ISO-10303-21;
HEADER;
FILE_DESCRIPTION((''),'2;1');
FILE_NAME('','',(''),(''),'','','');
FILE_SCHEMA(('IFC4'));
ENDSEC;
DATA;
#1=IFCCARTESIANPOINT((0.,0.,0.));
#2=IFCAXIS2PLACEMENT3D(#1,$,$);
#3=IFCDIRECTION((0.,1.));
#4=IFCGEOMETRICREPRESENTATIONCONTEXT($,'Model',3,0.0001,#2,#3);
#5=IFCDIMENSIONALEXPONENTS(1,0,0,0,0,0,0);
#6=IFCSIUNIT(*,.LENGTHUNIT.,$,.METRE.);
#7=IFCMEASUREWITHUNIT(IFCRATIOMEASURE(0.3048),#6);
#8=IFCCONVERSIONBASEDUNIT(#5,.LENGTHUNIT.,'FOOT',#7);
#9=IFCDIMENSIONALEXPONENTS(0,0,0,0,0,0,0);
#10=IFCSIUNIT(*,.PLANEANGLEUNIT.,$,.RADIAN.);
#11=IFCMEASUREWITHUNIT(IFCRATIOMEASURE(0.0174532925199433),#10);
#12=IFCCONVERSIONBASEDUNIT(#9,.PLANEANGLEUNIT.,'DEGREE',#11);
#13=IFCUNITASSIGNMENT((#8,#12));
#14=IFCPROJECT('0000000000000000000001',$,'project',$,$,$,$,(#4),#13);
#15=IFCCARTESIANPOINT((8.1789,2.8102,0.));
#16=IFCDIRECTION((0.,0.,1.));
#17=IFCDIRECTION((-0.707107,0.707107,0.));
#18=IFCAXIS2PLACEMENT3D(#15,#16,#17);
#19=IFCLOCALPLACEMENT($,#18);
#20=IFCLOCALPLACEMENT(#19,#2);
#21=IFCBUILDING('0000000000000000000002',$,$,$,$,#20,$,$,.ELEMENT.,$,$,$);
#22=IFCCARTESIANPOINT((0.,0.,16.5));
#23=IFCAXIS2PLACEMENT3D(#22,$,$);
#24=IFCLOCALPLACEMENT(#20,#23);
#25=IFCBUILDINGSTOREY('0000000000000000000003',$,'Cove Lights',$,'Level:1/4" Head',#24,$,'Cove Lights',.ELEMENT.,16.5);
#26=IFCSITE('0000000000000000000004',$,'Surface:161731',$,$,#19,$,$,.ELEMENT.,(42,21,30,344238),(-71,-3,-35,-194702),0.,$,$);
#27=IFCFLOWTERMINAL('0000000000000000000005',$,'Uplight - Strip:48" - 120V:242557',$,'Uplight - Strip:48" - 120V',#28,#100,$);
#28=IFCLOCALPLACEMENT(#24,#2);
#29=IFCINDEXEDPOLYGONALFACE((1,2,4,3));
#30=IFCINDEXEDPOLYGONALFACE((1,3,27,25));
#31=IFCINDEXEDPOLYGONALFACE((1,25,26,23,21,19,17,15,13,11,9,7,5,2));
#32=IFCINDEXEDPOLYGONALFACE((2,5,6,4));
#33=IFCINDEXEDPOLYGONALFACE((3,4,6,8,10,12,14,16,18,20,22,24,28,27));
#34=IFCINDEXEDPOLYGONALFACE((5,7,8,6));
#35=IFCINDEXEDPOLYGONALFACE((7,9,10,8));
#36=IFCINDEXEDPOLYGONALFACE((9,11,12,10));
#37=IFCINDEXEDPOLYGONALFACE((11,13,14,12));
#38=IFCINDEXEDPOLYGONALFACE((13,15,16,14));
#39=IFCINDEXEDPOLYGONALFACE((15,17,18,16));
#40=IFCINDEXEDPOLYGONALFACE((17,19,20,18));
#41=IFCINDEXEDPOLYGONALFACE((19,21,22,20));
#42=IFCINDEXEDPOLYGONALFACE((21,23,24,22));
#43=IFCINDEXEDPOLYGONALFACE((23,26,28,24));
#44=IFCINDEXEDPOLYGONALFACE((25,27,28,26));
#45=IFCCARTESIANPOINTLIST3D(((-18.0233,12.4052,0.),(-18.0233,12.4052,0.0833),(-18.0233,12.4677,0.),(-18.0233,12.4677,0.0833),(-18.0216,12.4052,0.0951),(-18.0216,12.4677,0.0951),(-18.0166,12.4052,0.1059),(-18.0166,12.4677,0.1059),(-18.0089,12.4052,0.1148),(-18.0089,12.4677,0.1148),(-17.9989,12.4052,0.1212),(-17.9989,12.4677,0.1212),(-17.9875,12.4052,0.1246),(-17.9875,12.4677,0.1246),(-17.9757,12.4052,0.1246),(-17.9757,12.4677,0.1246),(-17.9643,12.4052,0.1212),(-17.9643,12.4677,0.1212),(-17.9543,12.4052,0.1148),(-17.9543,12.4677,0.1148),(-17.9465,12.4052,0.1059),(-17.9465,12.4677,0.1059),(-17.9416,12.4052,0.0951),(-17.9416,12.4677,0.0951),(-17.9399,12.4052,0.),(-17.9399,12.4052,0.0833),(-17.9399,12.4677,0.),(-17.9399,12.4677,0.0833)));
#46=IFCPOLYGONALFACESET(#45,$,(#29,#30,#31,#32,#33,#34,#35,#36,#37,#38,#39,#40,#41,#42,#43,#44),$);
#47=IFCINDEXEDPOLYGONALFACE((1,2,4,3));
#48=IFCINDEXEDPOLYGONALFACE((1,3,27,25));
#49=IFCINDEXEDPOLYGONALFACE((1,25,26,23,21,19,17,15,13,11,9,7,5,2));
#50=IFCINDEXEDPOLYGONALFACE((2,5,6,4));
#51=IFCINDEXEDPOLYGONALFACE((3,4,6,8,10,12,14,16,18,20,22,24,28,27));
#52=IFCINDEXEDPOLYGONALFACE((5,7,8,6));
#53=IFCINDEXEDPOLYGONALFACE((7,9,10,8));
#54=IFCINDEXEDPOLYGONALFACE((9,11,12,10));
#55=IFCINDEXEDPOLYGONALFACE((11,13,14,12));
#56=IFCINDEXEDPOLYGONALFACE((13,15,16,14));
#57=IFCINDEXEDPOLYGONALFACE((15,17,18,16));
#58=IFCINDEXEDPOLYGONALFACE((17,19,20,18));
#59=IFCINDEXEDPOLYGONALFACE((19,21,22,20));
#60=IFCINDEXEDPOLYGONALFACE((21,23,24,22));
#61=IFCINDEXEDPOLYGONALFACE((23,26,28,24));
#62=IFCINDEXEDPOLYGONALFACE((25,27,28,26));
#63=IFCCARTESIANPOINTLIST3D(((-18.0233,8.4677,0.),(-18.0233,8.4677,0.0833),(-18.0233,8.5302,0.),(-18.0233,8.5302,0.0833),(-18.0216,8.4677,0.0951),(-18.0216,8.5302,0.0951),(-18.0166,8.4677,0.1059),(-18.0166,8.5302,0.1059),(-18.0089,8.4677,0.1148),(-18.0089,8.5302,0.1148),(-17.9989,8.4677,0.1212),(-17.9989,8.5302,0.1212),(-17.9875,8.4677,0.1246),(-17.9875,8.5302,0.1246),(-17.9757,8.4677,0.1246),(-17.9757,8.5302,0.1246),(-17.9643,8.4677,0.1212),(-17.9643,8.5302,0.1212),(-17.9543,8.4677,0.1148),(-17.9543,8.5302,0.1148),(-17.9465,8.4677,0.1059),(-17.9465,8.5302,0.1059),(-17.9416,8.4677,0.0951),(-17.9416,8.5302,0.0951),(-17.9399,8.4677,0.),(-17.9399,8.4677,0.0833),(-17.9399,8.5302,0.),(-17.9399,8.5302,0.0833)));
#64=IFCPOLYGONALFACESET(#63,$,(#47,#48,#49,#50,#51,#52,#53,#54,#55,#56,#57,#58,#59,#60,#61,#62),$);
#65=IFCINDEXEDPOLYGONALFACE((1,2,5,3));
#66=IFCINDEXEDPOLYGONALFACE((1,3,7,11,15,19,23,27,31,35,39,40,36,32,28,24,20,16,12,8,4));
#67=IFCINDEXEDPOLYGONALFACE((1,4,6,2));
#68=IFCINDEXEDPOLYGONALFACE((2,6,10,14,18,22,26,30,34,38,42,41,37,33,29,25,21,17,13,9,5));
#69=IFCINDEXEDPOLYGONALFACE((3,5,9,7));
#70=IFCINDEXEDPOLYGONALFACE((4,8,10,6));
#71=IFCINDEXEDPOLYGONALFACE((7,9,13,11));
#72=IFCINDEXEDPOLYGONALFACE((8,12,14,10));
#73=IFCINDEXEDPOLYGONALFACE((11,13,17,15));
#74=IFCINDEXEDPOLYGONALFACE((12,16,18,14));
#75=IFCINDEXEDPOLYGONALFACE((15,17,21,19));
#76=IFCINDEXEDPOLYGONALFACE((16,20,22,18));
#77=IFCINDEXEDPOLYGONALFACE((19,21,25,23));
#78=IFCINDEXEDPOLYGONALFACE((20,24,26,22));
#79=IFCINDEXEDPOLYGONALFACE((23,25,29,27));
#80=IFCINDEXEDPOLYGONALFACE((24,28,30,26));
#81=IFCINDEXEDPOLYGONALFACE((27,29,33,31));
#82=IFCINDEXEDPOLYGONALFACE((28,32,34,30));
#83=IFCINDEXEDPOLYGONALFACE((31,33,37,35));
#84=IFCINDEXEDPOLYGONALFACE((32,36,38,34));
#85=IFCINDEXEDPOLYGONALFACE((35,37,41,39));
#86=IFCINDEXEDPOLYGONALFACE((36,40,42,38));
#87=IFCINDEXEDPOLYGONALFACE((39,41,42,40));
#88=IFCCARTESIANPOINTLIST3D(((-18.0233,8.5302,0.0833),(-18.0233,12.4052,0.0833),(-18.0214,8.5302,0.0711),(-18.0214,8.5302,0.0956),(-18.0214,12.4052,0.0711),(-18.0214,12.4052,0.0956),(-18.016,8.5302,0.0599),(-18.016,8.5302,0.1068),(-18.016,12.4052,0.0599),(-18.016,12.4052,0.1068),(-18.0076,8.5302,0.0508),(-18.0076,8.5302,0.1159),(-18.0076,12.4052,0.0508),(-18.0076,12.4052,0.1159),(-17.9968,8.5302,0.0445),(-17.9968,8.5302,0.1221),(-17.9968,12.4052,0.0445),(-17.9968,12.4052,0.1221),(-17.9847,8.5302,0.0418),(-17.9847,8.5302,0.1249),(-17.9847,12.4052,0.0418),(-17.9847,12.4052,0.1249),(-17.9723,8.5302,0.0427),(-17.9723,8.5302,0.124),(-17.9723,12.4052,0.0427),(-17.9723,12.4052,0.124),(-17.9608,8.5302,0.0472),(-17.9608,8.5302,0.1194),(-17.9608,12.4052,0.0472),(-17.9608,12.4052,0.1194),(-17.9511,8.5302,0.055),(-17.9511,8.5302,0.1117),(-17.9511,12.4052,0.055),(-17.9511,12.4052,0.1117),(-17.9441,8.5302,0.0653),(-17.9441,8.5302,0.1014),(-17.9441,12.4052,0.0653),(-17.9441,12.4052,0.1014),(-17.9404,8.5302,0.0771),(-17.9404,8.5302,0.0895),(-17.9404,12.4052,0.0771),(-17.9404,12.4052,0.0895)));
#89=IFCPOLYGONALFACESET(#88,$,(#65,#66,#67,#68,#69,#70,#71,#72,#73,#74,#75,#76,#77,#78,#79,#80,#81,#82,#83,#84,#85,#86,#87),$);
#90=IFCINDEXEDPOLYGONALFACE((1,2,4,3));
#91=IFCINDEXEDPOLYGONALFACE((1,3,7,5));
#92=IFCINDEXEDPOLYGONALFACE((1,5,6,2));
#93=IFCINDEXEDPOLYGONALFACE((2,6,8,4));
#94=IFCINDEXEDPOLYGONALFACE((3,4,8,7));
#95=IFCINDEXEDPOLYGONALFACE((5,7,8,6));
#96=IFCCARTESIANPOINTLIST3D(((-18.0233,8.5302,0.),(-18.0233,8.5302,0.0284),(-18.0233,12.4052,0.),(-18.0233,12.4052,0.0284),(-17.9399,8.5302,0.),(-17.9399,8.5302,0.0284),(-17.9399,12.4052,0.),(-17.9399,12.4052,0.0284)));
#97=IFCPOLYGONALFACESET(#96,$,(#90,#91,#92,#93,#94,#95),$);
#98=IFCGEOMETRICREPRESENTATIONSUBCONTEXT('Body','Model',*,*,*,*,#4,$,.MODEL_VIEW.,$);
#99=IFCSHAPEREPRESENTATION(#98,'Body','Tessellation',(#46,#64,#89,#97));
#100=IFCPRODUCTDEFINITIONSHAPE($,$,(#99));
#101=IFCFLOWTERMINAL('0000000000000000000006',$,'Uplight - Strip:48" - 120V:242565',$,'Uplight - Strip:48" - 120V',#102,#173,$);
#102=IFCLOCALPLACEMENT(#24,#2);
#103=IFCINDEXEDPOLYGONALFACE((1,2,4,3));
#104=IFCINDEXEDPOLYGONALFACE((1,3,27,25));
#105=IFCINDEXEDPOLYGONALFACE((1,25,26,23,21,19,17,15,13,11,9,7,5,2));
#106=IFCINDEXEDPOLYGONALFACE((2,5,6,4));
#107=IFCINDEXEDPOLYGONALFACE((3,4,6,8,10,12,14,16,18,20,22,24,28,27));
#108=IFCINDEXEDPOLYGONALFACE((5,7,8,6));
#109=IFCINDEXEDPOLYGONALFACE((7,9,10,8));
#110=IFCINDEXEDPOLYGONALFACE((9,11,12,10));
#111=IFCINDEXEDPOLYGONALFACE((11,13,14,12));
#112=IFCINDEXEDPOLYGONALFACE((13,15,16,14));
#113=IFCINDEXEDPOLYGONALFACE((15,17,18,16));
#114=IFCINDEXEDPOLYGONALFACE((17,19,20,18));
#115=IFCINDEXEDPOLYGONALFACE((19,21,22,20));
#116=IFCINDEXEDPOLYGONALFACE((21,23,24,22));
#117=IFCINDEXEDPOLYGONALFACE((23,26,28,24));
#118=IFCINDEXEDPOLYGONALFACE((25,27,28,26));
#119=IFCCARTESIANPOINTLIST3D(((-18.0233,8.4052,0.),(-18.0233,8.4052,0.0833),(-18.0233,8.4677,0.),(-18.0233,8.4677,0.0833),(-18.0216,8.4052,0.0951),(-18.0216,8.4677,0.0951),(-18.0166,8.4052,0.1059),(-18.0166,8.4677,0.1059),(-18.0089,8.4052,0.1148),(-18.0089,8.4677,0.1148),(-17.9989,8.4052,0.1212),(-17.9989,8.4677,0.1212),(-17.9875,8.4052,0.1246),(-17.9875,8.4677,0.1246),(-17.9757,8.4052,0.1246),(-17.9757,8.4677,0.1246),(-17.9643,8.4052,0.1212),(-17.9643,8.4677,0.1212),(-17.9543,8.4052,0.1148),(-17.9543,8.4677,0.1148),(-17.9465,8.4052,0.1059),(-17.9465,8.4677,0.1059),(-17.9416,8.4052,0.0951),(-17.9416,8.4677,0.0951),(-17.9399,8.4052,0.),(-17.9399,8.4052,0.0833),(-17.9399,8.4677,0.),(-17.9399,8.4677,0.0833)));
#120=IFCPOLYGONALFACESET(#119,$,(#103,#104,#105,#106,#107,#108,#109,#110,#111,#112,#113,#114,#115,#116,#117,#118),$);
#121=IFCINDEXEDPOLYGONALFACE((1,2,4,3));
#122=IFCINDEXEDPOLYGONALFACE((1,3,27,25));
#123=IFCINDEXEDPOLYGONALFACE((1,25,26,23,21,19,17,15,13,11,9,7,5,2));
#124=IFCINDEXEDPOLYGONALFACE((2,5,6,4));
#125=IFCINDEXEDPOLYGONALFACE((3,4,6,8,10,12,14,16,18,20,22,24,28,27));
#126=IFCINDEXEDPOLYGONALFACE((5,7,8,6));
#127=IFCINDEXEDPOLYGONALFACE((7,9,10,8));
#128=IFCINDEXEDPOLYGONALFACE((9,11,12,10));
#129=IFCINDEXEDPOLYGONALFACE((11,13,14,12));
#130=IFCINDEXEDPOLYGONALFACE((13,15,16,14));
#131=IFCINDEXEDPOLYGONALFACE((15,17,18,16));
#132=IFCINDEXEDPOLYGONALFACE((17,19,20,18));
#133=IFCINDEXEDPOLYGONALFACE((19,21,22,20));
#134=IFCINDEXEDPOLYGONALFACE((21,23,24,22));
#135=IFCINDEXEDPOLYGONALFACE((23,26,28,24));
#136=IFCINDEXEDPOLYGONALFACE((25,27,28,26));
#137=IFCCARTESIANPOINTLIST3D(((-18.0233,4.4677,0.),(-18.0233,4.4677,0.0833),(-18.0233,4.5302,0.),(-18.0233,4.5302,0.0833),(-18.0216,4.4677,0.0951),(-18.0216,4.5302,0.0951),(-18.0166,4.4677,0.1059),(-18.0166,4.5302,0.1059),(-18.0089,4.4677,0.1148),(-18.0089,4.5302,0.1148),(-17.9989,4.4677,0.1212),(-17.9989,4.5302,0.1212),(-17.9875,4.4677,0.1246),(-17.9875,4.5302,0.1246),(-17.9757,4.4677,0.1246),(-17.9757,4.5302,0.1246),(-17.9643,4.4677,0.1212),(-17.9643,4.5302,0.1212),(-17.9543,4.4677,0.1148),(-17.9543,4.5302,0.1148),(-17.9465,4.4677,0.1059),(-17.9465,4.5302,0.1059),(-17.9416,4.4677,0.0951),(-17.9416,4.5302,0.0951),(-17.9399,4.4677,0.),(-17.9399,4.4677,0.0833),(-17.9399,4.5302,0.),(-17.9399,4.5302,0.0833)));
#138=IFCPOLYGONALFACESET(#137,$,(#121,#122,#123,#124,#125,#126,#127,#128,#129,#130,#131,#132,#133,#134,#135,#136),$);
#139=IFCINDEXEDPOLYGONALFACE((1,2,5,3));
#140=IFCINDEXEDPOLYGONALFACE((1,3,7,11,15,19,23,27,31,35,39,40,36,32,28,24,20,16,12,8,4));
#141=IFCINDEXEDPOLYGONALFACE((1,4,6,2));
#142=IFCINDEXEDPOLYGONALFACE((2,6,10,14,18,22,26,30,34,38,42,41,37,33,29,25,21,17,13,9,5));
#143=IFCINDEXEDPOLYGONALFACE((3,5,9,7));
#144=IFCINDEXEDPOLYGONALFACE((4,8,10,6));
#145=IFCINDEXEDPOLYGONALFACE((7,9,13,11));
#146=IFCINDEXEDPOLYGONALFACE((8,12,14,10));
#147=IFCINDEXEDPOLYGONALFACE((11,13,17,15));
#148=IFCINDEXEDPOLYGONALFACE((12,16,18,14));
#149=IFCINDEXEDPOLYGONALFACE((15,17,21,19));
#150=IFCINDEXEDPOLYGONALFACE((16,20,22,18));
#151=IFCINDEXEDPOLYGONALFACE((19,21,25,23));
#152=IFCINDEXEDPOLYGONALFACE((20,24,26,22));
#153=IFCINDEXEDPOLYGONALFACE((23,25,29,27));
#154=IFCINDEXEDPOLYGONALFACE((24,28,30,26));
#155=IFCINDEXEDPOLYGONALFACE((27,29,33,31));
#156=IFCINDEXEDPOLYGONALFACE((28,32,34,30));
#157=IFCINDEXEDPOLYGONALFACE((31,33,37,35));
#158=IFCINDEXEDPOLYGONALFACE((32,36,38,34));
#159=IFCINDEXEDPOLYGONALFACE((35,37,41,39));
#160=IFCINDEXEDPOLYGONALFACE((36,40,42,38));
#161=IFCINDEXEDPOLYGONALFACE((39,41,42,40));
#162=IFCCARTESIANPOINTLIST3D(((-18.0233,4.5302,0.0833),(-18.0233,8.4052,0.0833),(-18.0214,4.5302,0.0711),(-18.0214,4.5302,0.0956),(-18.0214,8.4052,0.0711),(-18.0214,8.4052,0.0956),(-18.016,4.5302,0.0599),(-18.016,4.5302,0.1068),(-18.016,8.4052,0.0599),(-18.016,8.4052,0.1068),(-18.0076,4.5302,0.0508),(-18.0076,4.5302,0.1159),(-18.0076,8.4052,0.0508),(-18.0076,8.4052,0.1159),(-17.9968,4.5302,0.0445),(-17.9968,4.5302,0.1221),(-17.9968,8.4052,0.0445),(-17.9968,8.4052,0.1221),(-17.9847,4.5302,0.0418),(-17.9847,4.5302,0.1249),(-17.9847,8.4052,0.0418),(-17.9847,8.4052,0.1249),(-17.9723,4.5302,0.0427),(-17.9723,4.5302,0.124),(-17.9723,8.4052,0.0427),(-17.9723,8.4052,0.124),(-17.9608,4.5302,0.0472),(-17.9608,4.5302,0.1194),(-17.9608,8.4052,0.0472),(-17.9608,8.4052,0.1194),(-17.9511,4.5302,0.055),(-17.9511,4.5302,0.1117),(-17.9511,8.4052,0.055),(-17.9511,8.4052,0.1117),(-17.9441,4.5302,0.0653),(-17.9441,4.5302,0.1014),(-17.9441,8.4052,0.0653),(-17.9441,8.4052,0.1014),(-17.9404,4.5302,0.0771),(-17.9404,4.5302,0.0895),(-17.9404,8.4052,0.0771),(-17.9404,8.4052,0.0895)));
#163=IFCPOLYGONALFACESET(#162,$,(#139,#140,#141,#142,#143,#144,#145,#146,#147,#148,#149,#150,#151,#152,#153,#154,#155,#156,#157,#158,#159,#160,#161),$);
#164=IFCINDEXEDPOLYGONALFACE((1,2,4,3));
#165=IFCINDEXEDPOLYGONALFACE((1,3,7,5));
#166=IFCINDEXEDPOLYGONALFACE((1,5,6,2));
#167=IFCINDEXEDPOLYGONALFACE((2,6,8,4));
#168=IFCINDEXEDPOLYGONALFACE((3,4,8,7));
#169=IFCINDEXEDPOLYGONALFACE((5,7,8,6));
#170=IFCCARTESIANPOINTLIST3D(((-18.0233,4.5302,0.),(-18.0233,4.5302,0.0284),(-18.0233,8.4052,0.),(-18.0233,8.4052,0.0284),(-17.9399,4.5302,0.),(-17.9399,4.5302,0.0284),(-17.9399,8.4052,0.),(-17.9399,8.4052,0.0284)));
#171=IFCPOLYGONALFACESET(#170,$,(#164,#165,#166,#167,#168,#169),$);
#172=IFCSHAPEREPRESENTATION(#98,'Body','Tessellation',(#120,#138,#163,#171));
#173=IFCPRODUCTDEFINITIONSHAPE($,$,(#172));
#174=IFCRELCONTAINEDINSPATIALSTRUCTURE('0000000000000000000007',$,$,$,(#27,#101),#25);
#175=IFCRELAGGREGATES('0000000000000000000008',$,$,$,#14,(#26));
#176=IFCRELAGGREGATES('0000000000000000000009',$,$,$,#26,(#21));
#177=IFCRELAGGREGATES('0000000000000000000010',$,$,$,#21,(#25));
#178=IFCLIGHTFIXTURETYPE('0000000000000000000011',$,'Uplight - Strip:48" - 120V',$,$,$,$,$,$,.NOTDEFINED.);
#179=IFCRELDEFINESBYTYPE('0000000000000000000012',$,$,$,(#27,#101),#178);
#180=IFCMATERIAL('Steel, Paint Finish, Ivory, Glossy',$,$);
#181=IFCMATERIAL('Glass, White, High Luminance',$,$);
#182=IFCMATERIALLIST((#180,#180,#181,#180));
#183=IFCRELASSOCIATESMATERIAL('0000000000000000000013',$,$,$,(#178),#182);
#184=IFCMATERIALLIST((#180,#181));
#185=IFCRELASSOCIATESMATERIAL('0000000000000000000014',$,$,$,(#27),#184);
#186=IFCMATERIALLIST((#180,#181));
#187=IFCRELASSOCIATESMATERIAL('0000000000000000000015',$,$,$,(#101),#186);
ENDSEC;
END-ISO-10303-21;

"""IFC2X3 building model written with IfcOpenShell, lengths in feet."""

from ifc_helpers import new_model, entity, si_unit, converted_unit, direction, frame, frame_2d, origin, origin_2d_with_axis, place, context, subcontext, project, spatial, polyline, circle_curve, parameter, trimmed, segment, composite_curve, rectangle, circle, outline, extrude, source, transform, mapped, material, material_list, type_object, type_shapes, element, save


model = new_model("IFC2X3")

# Units and contexts
model_context = context("Model", 3, precision=0.0001, world=origin(), true_north=direction((0.0, 1.0)))
body_context = subcontext(model_context, "Body", "Model", "MODEL_VIEW")
ifc_project = project(units=[converted_unit("LENGTHUNIT", "FOOT", entity("IfcRatioMeasure", 0.3048), si_unit("LENGTHUNIT", "METRE"), dimensions=[1, 0, 0, 0, 0, 0, 0]), converted_unit("PLANEANGLEUNIT", "DEGREE", entity("IfcRatioMeasure", 0.0174532925199433), si_unit("PLANEANGLEUNIT", "RADIAN"), dimensions=[0, 0, 0, 0, 0, 0, 0])], contexts=[model_context])

# Site, building, storey
site_placement = place(None, frame((8.1789, 2.8102, 0.0), z_axis=(0.0, 0.0, 1.0), x_axis=(-0.707107, 0.707107, 0.0)))
site = spatial("IfcSite", under=ifc_project, at=site_placement, Name="Surface:161731", CompositionType="ELEMENT", RefLatitude=(42, 21, 30, 344238), RefLongitude=(-71, -3, -35, -194702), RefElevation=0.0)
building_placement = place(site_placement, origin())
building = spatial("IfcBuilding", under=site, at=building_placement, CompositionType="ELEMENT")
storey_placement = place(building_placement, frame((0.0, 0.0, 16.5)))
storey = spatial("IfcBuildingStorey", under=building, at=storey_placement, Name="Cove Lights", ObjectType="Level:1/4\" Head", LongName="Cove Lights", CompositionType="ELEMENT", Elevation=16.5)

# Flow terminals
ifc_material_1 = material(Name="Steel, Paint Finish, Ivory, Glossy")
ifc_material_2 = material(Name="Glass, White, High Luminance")
ifc_material_list_1 = material_list([ifc_material_1, ifc_material_1, ifc_material_2, ifc_material_1])
light_fixture_type_1 = type_object("IfcLightFixtureType", Name="Uplight - Strip:48\" - 120V", PredefinedType="NOTDEFINED", material=ifc_material_list_1)
shared_shape_1 = source(origin(), body_context, "Body", "SweptSolid", [
    extrude(outline(composite_curve([segment(polyline([(-0.0417, -0.0417), (0.0417, -0.0417)]), True, "CONTINUOUS"), segment(trimmed(circle_curve(frame_2d((0.0417, 0.0), x_axis=(0.0, -1.0)), 0.0417), [parameter(0.0)], [parameter(180.0)], True, "PARAMETER"), True, "CONTINUOUS"), segment(polyline([(0.0417, 0.0417), (-0.0417, 0.0417)]), True, "CONTINUOUS"), segment(polyline([(-0.0417, 0.0417), (-0.0417, -0.0417)]), True, "CONTINUOUS")], self_intersect=False)), frame((1.9375, 0.0, 0.0417), z_axis=(1.0, 0.0, 0.0), x_axis=(0.0, 0.0, 1.0)), (0.0, 0.0, 1.0), 0.0625),
    extrude(outline(composite_curve([segment(polyline([(-0.0417, -0.0417), (0.0417, -0.0417)]), True, "CONTINUOUS"), segment(polyline([(0.0417, -0.0417), (0.0417, 0.0417)]), True, "CONTINUOUS"), segment(trimmed(circle_curve(frame_2d((0.0, 0.0417), x_axis=(0.0, 1.0)), 0.0417), [parameter(270.0)], [parameter(90.0)], True, "PARAMETER"), True, "CONTINUOUS"), segment(polyline([(-0.0417, 0.0417), (-0.0417, -0.0417)]), True, "CONTINUOUS")], self_intersect=False)), frame((-2.0, 0.0, 0.0417), z_axis=(1.0, 0.0, 0.0), x_axis=(0.0, 1.0, 0.0)), (0.0, 0.0, 1.0), 0.0625),
    extrude(circle(Radius=0.0417, at=frame_2d((0.0, 0.0), x_axis=(1.0, 0.0))), frame((-1.9375, 0.0, 0.0833), z_axis=(1.0, 0.0, 0.0), x_axis=(0.0, 1.0, 0.0)), (0.0, 0.0, 1.0), 3.875),
    extrude(rectangle(XDim=3.875, YDim=0.0833, at=origin_2d_with_axis()), frame((0.0, 0.0, 0.0), z_axis=(0.0, 0.0, 1.0), x_axis=(-1.0, 0.0, 0.0)), (0.0, 0.0, 1.0), 0.0284),
])
type_shapes(light_fixture_type_1, [shared_shape_1])
ifc_material_list_2 = material_list([ifc_material_1, ifc_material_2])
flow_terminal_1_placement = place(storey_placement, frame((-17.9816, 10.4677, 0.0), z_axis=(0.0, 0.0, 1.0), x_axis=(0.0, 1.0, 0.0)))
element("IfcFlowTerminal", 1, at=flow_terminal_1_placement, inside=storey, type_object=light_fixture_type_1, material=ifc_material_list_2, Name="Uplight - Strip:48\" - 120V:242557", ObjectType="Uplight - Strip:48\" - 120V", context=body_context, shape_type="MappedRepresentation", body=[
    mapped(shared_shape_1, transform((0.0, 0.0, 0.0), scale=1.0)),
])
ifc_material_list_3 = material_list([ifc_material_1, ifc_material_2])
flow_terminal_2_placement = place(storey_placement, frame((-17.9816, 6.4677, 0.0), z_axis=(0.0, 0.0, 1.0), x_axis=(0.0, 1.0, 0.0)))
element("IfcFlowTerminal", 2, at=flow_terminal_2_placement, inside=storey, type_object=light_fixture_type_1, material=ifc_material_list_3, Name="Uplight - Strip:48\" - 120V:242565", ObjectType="Uplight - Strip:48\" - 120V", context=body_context, shape_type="MappedRepresentation", body=[
    mapped(shared_shape_1, transform((0.0, 0.0, 0.0), scale=1.0)),
])

save(model, "model.ifc")
